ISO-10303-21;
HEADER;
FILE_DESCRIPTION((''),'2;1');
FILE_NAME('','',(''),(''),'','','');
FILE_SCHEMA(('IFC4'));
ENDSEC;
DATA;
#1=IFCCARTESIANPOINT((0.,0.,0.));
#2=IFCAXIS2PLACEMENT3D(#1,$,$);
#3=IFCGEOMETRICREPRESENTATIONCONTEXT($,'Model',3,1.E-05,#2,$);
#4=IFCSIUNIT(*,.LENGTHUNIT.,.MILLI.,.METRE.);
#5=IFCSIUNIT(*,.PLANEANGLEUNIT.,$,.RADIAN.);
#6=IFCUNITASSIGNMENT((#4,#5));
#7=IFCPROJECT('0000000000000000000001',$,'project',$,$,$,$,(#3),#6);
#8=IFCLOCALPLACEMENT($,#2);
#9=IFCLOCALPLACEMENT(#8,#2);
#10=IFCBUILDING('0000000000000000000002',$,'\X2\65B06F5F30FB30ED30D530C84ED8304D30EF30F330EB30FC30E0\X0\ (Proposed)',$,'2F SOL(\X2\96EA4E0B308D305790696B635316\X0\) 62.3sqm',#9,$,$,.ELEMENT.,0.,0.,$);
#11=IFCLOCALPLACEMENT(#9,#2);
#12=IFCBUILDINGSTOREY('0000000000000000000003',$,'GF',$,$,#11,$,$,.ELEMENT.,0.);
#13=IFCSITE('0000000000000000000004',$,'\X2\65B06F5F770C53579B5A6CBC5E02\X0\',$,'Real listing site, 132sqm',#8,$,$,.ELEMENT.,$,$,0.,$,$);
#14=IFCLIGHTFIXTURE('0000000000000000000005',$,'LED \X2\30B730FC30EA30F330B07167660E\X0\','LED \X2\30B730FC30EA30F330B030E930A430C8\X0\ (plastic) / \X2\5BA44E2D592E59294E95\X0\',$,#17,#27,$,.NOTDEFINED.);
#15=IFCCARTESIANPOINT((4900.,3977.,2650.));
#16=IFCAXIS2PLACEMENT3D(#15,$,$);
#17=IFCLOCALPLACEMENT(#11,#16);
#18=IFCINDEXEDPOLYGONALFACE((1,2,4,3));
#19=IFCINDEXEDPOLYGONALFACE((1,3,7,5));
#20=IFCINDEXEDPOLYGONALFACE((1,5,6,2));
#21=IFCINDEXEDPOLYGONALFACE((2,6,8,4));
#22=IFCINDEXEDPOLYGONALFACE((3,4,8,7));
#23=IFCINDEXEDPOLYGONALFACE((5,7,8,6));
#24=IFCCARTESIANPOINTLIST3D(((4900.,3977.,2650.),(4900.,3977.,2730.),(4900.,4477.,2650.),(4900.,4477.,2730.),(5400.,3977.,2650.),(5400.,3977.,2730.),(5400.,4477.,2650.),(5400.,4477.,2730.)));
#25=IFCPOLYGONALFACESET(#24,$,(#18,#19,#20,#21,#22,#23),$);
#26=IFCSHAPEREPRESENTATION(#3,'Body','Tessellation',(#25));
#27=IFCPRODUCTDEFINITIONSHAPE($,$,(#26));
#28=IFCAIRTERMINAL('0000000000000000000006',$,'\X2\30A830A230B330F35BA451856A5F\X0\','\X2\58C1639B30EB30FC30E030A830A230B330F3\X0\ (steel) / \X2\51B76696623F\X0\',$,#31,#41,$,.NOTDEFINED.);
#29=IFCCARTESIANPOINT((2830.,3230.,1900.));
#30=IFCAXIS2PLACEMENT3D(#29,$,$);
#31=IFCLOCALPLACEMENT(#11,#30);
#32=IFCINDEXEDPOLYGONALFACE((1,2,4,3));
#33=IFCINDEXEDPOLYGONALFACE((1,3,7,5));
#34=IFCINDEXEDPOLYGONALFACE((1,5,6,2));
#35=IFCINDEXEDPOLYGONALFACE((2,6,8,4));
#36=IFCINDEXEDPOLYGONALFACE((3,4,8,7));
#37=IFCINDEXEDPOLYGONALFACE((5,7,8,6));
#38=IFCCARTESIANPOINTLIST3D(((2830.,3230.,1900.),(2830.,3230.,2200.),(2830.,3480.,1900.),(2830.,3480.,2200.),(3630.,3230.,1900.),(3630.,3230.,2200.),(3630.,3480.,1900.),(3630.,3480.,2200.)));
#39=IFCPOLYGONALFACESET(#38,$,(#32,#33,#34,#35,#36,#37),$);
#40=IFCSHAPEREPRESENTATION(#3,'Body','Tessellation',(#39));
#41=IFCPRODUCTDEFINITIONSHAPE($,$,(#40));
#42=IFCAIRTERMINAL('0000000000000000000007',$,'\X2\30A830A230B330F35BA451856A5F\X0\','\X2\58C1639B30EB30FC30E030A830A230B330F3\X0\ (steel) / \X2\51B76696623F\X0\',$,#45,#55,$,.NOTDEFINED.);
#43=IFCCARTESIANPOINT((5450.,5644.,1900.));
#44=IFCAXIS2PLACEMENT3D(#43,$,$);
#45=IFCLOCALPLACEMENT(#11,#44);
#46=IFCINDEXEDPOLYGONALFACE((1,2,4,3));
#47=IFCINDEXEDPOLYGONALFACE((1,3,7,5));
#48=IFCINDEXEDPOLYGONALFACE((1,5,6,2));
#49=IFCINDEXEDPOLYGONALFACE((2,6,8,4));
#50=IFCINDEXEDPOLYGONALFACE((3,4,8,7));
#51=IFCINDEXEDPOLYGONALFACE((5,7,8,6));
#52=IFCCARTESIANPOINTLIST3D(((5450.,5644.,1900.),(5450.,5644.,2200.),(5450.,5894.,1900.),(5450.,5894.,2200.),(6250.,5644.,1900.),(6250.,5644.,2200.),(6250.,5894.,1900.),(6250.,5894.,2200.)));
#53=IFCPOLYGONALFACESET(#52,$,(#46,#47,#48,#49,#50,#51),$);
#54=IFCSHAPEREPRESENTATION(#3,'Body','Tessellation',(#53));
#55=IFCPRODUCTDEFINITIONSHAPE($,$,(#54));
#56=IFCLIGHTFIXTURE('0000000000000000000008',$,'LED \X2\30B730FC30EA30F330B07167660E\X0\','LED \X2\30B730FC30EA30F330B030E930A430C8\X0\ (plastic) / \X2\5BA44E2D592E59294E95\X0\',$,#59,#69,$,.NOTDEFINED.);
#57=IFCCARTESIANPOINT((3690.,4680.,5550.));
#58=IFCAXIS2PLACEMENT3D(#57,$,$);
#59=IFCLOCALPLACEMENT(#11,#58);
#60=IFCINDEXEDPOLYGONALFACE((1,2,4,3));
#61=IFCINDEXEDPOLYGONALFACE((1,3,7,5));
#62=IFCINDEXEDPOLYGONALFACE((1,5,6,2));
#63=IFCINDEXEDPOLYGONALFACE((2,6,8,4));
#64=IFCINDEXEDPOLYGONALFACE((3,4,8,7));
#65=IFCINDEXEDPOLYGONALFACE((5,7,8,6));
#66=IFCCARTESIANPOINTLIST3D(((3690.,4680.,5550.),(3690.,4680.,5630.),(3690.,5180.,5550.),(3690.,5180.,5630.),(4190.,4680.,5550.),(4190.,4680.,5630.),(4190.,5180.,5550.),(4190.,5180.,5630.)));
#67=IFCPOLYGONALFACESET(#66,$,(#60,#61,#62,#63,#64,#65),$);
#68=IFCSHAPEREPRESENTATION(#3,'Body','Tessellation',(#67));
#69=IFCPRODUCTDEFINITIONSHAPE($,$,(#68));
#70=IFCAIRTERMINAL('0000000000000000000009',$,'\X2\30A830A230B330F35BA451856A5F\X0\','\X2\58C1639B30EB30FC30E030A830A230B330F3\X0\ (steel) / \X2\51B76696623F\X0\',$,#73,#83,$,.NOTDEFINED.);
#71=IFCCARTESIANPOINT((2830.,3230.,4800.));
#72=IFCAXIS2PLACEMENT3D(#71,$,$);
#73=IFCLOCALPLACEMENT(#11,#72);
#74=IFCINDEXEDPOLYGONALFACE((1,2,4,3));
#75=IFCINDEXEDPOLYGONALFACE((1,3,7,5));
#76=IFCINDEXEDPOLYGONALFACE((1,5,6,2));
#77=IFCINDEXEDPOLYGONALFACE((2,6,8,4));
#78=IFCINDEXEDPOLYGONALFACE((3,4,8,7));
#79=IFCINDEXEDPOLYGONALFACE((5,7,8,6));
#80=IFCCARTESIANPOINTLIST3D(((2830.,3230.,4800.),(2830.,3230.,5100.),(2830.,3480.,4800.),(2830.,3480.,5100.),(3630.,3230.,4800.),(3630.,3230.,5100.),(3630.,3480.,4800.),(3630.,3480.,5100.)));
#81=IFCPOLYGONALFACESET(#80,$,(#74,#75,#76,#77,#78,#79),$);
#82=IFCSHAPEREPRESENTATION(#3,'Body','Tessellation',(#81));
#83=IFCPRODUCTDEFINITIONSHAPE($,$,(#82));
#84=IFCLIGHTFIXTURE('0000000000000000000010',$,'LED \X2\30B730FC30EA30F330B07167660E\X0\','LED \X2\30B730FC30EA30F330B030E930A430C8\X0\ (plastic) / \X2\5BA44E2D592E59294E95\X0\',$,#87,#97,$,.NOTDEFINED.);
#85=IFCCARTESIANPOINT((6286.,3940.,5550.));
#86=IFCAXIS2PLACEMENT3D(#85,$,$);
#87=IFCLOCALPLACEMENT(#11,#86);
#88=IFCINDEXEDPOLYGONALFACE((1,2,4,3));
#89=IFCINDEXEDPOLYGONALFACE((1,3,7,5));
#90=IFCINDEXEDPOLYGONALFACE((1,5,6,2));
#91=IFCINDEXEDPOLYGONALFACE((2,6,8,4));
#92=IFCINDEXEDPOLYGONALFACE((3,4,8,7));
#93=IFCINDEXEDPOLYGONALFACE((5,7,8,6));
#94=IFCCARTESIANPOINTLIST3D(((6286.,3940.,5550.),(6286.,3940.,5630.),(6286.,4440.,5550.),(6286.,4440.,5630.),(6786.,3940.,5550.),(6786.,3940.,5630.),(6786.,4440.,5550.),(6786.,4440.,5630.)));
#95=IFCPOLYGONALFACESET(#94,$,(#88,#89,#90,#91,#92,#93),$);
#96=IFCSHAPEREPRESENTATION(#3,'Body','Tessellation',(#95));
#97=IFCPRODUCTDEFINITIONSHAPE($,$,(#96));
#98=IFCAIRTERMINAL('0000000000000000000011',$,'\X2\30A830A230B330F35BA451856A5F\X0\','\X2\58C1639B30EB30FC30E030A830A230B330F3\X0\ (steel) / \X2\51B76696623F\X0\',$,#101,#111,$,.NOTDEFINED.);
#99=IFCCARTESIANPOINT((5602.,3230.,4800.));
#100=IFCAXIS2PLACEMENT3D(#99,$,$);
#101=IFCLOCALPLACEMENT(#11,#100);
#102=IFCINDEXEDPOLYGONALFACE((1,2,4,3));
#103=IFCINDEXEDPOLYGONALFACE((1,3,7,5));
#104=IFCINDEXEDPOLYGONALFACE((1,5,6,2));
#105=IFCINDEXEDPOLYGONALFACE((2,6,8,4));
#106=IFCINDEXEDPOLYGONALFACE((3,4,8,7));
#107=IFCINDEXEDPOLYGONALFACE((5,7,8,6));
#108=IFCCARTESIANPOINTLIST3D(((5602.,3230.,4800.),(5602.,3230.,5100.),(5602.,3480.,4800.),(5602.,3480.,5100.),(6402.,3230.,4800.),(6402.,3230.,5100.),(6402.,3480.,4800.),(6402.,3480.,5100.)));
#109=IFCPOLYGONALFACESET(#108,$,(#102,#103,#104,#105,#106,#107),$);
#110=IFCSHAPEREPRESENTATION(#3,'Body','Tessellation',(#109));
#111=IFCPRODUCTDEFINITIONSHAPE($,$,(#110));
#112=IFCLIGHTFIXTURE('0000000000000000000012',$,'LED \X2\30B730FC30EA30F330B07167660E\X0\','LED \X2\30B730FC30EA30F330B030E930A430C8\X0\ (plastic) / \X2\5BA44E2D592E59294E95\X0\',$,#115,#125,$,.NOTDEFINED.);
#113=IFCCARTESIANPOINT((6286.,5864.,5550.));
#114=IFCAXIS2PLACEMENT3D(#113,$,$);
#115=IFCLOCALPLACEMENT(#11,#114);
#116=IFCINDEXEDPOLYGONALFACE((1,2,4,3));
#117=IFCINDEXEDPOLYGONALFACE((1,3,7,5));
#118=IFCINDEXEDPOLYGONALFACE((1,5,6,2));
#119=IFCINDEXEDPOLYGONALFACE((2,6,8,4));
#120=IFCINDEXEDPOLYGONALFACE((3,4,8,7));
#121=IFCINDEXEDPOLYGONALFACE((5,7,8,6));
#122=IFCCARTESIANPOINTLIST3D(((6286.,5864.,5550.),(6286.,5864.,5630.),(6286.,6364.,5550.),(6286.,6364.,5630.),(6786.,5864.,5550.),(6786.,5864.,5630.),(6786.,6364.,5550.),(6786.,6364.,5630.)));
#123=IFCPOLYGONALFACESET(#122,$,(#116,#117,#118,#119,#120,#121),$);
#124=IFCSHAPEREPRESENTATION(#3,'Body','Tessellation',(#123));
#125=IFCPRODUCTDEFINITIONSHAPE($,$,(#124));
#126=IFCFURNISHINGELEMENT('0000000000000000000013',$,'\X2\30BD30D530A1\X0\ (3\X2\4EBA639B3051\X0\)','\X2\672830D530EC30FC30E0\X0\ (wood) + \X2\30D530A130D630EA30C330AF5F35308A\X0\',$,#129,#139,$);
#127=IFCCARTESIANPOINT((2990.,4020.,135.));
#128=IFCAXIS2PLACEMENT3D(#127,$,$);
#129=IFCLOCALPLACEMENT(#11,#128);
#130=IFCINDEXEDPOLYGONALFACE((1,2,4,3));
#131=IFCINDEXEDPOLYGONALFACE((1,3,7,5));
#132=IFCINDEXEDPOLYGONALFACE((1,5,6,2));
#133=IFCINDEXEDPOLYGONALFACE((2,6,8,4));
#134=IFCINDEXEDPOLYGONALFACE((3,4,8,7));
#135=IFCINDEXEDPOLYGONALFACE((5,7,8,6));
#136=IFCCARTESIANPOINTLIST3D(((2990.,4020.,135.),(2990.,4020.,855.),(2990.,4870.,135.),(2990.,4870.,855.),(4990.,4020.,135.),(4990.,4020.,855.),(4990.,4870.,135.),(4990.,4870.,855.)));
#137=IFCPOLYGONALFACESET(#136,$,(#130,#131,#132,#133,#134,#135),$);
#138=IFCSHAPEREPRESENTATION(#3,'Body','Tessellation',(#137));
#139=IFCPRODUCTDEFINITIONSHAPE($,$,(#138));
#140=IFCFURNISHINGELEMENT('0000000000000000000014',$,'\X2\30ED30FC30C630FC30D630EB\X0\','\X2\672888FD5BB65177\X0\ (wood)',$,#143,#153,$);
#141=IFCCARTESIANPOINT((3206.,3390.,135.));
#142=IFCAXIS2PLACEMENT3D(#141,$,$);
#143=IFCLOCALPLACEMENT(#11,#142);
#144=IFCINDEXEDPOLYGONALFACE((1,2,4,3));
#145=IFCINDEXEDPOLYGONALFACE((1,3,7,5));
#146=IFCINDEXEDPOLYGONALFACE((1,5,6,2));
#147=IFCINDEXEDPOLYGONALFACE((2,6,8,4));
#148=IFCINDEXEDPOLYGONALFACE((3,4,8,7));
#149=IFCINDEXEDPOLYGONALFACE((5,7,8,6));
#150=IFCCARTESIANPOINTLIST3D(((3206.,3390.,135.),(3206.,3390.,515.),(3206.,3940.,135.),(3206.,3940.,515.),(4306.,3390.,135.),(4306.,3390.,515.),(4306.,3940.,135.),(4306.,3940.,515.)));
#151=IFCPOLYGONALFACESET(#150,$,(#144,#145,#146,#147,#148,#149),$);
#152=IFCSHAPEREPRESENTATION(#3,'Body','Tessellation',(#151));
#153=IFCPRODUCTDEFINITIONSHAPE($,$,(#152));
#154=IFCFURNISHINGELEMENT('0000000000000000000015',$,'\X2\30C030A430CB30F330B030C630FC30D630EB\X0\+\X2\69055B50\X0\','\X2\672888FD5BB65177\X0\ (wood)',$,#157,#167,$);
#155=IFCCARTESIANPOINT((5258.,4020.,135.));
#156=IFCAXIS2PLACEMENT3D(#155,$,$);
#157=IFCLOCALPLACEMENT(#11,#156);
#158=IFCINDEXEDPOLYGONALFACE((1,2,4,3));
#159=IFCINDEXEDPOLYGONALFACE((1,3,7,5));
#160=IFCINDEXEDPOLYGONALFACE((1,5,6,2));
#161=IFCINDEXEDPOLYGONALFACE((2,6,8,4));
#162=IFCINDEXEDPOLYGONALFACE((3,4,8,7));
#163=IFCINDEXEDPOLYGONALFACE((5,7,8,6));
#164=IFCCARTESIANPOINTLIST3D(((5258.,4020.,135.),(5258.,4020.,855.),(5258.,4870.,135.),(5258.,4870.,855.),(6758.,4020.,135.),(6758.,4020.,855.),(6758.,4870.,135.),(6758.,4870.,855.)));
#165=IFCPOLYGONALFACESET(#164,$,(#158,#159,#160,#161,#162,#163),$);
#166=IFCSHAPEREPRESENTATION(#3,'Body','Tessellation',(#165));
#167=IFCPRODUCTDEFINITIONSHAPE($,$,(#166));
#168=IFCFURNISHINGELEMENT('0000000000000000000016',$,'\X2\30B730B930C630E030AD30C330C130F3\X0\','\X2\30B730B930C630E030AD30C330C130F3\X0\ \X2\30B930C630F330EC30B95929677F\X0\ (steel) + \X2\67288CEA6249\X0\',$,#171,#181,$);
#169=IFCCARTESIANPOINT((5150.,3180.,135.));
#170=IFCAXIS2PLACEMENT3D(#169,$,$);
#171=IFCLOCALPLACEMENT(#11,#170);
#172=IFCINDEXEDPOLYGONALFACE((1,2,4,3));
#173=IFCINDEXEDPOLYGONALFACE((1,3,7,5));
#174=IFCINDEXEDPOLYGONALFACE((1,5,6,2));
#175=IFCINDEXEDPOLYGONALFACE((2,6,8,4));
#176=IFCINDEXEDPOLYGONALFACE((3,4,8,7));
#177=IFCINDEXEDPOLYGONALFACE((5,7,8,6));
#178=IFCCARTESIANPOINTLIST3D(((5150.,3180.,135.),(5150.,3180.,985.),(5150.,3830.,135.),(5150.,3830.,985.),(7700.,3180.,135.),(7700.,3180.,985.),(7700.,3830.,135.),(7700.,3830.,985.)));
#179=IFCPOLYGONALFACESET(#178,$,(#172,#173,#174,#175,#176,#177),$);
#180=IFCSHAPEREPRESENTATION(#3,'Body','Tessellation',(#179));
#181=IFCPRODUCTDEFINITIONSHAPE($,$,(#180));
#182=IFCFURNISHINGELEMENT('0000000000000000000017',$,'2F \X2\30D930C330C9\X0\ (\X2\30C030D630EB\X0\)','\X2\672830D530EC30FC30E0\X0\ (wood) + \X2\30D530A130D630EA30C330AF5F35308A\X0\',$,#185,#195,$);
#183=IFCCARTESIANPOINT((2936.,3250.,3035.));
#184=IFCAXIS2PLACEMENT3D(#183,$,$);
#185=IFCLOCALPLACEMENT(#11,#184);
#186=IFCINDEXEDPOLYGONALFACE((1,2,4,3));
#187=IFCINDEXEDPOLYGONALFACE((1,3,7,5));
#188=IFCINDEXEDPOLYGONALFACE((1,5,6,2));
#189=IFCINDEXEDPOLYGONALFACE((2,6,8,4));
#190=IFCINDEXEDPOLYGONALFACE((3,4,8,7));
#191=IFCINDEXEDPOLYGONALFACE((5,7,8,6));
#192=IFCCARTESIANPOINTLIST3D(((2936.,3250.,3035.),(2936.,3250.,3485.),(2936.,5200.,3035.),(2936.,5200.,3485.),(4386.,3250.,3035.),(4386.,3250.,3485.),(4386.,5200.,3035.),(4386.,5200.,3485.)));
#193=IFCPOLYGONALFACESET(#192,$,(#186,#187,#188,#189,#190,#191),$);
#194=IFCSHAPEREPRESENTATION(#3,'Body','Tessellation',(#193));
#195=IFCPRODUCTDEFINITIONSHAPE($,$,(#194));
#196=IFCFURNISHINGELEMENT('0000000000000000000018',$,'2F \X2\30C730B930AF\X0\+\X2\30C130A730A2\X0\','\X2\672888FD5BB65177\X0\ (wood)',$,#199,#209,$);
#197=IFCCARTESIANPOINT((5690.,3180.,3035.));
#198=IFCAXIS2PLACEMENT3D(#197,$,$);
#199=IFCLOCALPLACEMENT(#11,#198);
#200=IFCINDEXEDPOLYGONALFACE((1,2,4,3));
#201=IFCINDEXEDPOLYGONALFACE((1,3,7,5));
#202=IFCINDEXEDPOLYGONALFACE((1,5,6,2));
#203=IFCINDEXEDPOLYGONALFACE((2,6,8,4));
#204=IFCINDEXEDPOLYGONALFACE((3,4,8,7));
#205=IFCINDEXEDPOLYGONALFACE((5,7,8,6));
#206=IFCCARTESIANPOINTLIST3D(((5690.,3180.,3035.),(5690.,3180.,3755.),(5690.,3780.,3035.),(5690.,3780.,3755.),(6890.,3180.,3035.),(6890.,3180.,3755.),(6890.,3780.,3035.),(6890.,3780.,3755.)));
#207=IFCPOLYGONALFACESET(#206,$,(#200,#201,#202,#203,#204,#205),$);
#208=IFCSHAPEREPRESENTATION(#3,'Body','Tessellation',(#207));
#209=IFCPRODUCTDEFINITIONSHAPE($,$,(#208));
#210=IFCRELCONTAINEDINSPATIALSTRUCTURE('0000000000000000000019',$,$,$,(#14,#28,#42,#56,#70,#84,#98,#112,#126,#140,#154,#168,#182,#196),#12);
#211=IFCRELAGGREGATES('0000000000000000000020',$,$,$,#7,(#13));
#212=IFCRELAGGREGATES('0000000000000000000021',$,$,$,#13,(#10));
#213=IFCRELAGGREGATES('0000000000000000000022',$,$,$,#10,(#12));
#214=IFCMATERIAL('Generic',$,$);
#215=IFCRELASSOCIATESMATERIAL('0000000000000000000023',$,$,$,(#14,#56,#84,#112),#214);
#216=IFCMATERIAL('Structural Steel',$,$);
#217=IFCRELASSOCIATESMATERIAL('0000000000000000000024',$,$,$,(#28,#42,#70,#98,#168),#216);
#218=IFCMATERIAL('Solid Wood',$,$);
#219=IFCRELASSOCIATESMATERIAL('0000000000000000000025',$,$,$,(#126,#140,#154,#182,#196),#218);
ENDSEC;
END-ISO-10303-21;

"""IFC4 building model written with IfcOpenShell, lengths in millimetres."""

from ifc_helpers import new_model, si_unit, frame, frame_2d, origin, place, context, project, spatial, rectangle, extrude, material, element, save


model = new_model("IFC4")

# Units and contexts
model_context = context("Model", 3, precision=1e-05, world=origin())
ifc_project = project(units=[si_unit("LENGTHUNIT", "METRE", prefix="MILLI"), si_unit("PLANEANGLEUNIT", "RADIAN")], contexts=[model_context])

# Site, building, storey
site_placement = place(None, origin())
site = spatial("IfcSite", under=ifc_project, at=site_placement, Name="新潟県南魚沼市", ObjectType="Real listing site, 132sqm", CompositionType="ELEMENT", RefElevation=0.0)
building_placement = place(site_placement, origin())
building = spatial("IfcBuilding", under=site, at=building_placement, Name="新潟・ロフト付きワンルーム (Proposed)", ObjectType="2F SOL(雪下ろし適正化) 62.3sqm", CompositionType="ELEMENT", ElevationOfRefHeight=0.0, ElevationOfTerrain=0.0)
storey_placement = place(building_placement, origin())
storey = spatial("IfcBuildingStorey", under=building, at=storey_placement, Name="GF", CompositionType="ELEMENT", Elevation=0.0)

# Shared definitions
ifc_material_1 = material(Name="Solid Wood")

# Shared definitions
ifc_material_2 = material(Name="Structural Steel")

# Shared definitions
ifc_material_3 = material(Name="Generic")

# Light fixture
light_fixture_1_placement = place(storey_placement, frame((4900.0, 3977.0, 2650.0)))
element("IfcLightFixture", 1, at=light_fixture_1_placement, inside=storey, material=ifc_material_3, Name="LED シーリング照明", Description="LED シーリングライト (plastic) / 室中央天井", PredefinedType="NOTDEFINED", context=model_context, shape_type="SweptSolid", body=[
    extrude(rectangle(XDim=500.0, YDim=500.0, at=frame_2d((250.0, 250.0))), frame((4900.0, 3977.0, 2650.0)), (0.0, 0.0, 1.0), 80.0),
])

# Air terminals
air_terminal_1_placement = place(storey_placement, frame((2830.0, 3230.0, 1900.0)))
element("IfcAirTerminal", 2, at=air_terminal_1_placement, inside=storey, material=ifc_material_2, Name="エアコン室内機", Description="壁掛ルームエアコン (steel) / 冷暖房", PredefinedType="NOTDEFINED", context=model_context, shape_type="SweptSolid", body=[
    extrude(rectangle(XDim=800.0, YDim=250.0, at=frame_2d((400.0, 125.0))), frame((2830.0, 3230.0, 1900.0)), (0.0, 0.0, 1.0), 300.0),
])
air_terminal_2_placement = place(storey_placement, frame((5450.0, 5644.0, 1900.0)))
element("IfcAirTerminal", 3, at=air_terminal_2_placement, inside=storey, material=ifc_material_2, Name="エアコン室内機", Description="壁掛ルームエアコン (steel) / 冷暖房", PredefinedType="NOTDEFINED", context=model_context, shape_type="SweptSolid", body=[
    extrude(rectangle(XDim=800.0, YDim=250.0, at=frame_2d((400.0, 125.0))), frame((5450.0, 5644.0, 1900.0)), (0.0, 0.0, 1.0), 300.0),
])

# Light fixture
light_fixture_2_placement = place(storey_placement, frame((3690.0, 4680.0, 5550.0)))
element("IfcLightFixture", 4, at=light_fixture_2_placement, inside=storey, material=ifc_material_3, Name="LED シーリング照明", Description="LED シーリングライト (plastic) / 室中央天井", PredefinedType="NOTDEFINED", context=model_context, shape_type="SweptSolid", body=[
    extrude(rectangle(XDim=500.0, YDim=500.0, at=frame_2d((250.0, 250.0))), frame((3690.0, 4680.0, 5550.0)), (0.0, 0.0, 1.0), 80.0),
])

# Air terminal
air_terminal_3_placement = place(storey_placement, frame((2830.0, 3230.0, 4800.0)))
element("IfcAirTerminal", 5, at=air_terminal_3_placement, inside=storey, material=ifc_material_2, Name="エアコン室内機", Description="壁掛ルームエアコン (steel) / 冷暖房", PredefinedType="NOTDEFINED", context=model_context, shape_type="SweptSolid", body=[
    extrude(rectangle(XDim=800.0, YDim=250.0, at=frame_2d((400.0, 125.0))), frame((2830.0, 3230.0, 4800.0)), (0.0, 0.0, 1.0), 300.0),
])

# Light fixture
light_fixture_3_placement = place(storey_placement, frame((6286.0, 3940.0, 5550.0)))
element("IfcLightFixture", 6, at=light_fixture_3_placement, inside=storey, material=ifc_material_3, Name="LED シーリング照明", Description="LED シーリングライト (plastic) / 室中央天井", PredefinedType="NOTDEFINED", context=model_context, shape_type="SweptSolid", body=[
    extrude(rectangle(XDim=500.0, YDim=500.0, at=frame_2d((250.0, 250.0))), frame((6286.0, 3940.0, 5550.0)), (0.0, 0.0, 1.0), 80.0),
])

# Air terminal
air_terminal_4_placement = place(storey_placement, frame((5602.0, 3230.0, 4800.0)))
element("IfcAirTerminal", 7, at=air_terminal_4_placement, inside=storey, material=ifc_material_2, Name="エアコン室内機", Description="壁掛ルームエアコン (steel) / 冷暖房", PredefinedType="NOTDEFINED", context=model_context, shape_type="SweptSolid", body=[
    extrude(rectangle(XDim=800.0, YDim=250.0, at=frame_2d((400.0, 125.0))), frame((5602.0, 3230.0, 4800.0)), (0.0, 0.0, 1.0), 300.0),
])

# Light fixture
light_fixture_4_placement = place(storey_placement, frame((6286.0, 5864.0, 5550.0)))
element("IfcLightFixture", 8, at=light_fixture_4_placement, inside=storey, material=ifc_material_3, Name="LED シーリング照明", Description="LED シーリングライト (plastic) / 室中央天井", PredefinedType="NOTDEFINED", context=model_context, shape_type="SweptSolid", body=[
    extrude(rectangle(XDim=500.0, YDim=500.0, at=frame_2d((250.0, 250.0))), frame((6286.0, 5864.0, 5550.0)), (0.0, 0.0, 1.0), 80.0),
])

# Furnishing elements
furnishing_1_placement = place(storey_placement, frame((2990.0, 4020.0, 135.0)))
element("IfcFurnishingElement", 9, at=furnishing_1_placement, inside=storey, material=ifc_material_1, Name="ソファ (3人掛け)", Description="木フレーム (wood) + ファブリック張り", context=model_context, shape_type="SweptSolid", body=[
    extrude(rectangle(XDim=2000.0, YDim=850.0, at=frame_2d((1000.0, 425.0))), frame((2990.0, 4020.0, 135.0)), (0.0, 0.0, 1.0), 720.0),
])
furnishing_2_placement = place(storey_placement, frame((3206.0, 3390.0, 135.0)))
element("IfcFurnishingElement", 10, at=furnishing_2_placement, inside=storey, material=ifc_material_1, Name="ローテーブル", Description="木製家具 (wood)", context=model_context, shape_type="SweptSolid", body=[
    extrude(rectangle(XDim=1100.0, YDim=550.0, at=frame_2d((550.0, 275.0))), frame((3206.0, 3390.0, 135.0)), (0.0, 0.0, 1.0), 380.0),
])
furnishing_3_placement = place(storey_placement, frame((5258.0, 4020.0, 135.0)))
element("IfcFurnishingElement", 11, at=furnishing_3_placement, inside=storey, material=ifc_material_1, Name="ダイニングテーブル+椅子", Description="木製家具 (wood)", context=model_context, shape_type="SweptSolid", body=[
    extrude(rectangle(XDim=1500.0, YDim=850.0, at=frame_2d((750.0, 425.0))), frame((5258.0, 4020.0, 135.0)), (0.0, 0.0, 1.0), 720.0),
])
furnishing_4_placement = place(storey_placement, frame((5150.0, 3180.0, 135.0)))
element("IfcFurnishingElement", 12, at=furnishing_4_placement, inside=storey, material=ifc_material_2, Name="システムキッチン", Description="システムキッチン ステンレス天板 (steel) + 木質扉", context=model_context, shape_type="SweptSolid", body=[
    extrude(rectangle(XDim=2550.0, YDim=650.0, at=frame_2d((1275.0, 325.0))), frame((5150.0, 3180.0, 135.0)), (0.0, 0.0, 1.0), 850.0),
])
furnishing_5_placement = place(storey_placement, frame((2936.0, 3250.0, 3035.0)))
element("IfcFurnishingElement", 13, at=furnishing_5_placement, inside=storey, material=ifc_material_1, Name="2F ベッド (ダブル)", Description="木フレーム (wood) + ファブリック張り", context=model_context, shape_type="SweptSolid", body=[
    extrude(rectangle(XDim=1450.0, YDim=1950.0, at=frame_2d((725.0, 975.0))), frame((2936.0, 3250.0, 3035.0)), (0.0, 0.0, 1.0), 450.0),
])
furnishing_6_placement = place(storey_placement, frame((5690.0, 3180.0, 3035.0)))
element("IfcFurnishingElement", 14, at=furnishing_6_placement, inside=storey, material=ifc_material_1, Name="2F デスク+チェア", Description="木製家具 (wood)", context=model_context, shape_type="SweptSolid", body=[
    extrude(rectangle(XDim=1200.0, YDim=600.0, at=frame_2d((600.0, 300.0))), frame((5690.0, 3180.0, 3035.0)), (0.0, 0.0, 1.0), 720.0),
])

save(model, "model.ifc")
